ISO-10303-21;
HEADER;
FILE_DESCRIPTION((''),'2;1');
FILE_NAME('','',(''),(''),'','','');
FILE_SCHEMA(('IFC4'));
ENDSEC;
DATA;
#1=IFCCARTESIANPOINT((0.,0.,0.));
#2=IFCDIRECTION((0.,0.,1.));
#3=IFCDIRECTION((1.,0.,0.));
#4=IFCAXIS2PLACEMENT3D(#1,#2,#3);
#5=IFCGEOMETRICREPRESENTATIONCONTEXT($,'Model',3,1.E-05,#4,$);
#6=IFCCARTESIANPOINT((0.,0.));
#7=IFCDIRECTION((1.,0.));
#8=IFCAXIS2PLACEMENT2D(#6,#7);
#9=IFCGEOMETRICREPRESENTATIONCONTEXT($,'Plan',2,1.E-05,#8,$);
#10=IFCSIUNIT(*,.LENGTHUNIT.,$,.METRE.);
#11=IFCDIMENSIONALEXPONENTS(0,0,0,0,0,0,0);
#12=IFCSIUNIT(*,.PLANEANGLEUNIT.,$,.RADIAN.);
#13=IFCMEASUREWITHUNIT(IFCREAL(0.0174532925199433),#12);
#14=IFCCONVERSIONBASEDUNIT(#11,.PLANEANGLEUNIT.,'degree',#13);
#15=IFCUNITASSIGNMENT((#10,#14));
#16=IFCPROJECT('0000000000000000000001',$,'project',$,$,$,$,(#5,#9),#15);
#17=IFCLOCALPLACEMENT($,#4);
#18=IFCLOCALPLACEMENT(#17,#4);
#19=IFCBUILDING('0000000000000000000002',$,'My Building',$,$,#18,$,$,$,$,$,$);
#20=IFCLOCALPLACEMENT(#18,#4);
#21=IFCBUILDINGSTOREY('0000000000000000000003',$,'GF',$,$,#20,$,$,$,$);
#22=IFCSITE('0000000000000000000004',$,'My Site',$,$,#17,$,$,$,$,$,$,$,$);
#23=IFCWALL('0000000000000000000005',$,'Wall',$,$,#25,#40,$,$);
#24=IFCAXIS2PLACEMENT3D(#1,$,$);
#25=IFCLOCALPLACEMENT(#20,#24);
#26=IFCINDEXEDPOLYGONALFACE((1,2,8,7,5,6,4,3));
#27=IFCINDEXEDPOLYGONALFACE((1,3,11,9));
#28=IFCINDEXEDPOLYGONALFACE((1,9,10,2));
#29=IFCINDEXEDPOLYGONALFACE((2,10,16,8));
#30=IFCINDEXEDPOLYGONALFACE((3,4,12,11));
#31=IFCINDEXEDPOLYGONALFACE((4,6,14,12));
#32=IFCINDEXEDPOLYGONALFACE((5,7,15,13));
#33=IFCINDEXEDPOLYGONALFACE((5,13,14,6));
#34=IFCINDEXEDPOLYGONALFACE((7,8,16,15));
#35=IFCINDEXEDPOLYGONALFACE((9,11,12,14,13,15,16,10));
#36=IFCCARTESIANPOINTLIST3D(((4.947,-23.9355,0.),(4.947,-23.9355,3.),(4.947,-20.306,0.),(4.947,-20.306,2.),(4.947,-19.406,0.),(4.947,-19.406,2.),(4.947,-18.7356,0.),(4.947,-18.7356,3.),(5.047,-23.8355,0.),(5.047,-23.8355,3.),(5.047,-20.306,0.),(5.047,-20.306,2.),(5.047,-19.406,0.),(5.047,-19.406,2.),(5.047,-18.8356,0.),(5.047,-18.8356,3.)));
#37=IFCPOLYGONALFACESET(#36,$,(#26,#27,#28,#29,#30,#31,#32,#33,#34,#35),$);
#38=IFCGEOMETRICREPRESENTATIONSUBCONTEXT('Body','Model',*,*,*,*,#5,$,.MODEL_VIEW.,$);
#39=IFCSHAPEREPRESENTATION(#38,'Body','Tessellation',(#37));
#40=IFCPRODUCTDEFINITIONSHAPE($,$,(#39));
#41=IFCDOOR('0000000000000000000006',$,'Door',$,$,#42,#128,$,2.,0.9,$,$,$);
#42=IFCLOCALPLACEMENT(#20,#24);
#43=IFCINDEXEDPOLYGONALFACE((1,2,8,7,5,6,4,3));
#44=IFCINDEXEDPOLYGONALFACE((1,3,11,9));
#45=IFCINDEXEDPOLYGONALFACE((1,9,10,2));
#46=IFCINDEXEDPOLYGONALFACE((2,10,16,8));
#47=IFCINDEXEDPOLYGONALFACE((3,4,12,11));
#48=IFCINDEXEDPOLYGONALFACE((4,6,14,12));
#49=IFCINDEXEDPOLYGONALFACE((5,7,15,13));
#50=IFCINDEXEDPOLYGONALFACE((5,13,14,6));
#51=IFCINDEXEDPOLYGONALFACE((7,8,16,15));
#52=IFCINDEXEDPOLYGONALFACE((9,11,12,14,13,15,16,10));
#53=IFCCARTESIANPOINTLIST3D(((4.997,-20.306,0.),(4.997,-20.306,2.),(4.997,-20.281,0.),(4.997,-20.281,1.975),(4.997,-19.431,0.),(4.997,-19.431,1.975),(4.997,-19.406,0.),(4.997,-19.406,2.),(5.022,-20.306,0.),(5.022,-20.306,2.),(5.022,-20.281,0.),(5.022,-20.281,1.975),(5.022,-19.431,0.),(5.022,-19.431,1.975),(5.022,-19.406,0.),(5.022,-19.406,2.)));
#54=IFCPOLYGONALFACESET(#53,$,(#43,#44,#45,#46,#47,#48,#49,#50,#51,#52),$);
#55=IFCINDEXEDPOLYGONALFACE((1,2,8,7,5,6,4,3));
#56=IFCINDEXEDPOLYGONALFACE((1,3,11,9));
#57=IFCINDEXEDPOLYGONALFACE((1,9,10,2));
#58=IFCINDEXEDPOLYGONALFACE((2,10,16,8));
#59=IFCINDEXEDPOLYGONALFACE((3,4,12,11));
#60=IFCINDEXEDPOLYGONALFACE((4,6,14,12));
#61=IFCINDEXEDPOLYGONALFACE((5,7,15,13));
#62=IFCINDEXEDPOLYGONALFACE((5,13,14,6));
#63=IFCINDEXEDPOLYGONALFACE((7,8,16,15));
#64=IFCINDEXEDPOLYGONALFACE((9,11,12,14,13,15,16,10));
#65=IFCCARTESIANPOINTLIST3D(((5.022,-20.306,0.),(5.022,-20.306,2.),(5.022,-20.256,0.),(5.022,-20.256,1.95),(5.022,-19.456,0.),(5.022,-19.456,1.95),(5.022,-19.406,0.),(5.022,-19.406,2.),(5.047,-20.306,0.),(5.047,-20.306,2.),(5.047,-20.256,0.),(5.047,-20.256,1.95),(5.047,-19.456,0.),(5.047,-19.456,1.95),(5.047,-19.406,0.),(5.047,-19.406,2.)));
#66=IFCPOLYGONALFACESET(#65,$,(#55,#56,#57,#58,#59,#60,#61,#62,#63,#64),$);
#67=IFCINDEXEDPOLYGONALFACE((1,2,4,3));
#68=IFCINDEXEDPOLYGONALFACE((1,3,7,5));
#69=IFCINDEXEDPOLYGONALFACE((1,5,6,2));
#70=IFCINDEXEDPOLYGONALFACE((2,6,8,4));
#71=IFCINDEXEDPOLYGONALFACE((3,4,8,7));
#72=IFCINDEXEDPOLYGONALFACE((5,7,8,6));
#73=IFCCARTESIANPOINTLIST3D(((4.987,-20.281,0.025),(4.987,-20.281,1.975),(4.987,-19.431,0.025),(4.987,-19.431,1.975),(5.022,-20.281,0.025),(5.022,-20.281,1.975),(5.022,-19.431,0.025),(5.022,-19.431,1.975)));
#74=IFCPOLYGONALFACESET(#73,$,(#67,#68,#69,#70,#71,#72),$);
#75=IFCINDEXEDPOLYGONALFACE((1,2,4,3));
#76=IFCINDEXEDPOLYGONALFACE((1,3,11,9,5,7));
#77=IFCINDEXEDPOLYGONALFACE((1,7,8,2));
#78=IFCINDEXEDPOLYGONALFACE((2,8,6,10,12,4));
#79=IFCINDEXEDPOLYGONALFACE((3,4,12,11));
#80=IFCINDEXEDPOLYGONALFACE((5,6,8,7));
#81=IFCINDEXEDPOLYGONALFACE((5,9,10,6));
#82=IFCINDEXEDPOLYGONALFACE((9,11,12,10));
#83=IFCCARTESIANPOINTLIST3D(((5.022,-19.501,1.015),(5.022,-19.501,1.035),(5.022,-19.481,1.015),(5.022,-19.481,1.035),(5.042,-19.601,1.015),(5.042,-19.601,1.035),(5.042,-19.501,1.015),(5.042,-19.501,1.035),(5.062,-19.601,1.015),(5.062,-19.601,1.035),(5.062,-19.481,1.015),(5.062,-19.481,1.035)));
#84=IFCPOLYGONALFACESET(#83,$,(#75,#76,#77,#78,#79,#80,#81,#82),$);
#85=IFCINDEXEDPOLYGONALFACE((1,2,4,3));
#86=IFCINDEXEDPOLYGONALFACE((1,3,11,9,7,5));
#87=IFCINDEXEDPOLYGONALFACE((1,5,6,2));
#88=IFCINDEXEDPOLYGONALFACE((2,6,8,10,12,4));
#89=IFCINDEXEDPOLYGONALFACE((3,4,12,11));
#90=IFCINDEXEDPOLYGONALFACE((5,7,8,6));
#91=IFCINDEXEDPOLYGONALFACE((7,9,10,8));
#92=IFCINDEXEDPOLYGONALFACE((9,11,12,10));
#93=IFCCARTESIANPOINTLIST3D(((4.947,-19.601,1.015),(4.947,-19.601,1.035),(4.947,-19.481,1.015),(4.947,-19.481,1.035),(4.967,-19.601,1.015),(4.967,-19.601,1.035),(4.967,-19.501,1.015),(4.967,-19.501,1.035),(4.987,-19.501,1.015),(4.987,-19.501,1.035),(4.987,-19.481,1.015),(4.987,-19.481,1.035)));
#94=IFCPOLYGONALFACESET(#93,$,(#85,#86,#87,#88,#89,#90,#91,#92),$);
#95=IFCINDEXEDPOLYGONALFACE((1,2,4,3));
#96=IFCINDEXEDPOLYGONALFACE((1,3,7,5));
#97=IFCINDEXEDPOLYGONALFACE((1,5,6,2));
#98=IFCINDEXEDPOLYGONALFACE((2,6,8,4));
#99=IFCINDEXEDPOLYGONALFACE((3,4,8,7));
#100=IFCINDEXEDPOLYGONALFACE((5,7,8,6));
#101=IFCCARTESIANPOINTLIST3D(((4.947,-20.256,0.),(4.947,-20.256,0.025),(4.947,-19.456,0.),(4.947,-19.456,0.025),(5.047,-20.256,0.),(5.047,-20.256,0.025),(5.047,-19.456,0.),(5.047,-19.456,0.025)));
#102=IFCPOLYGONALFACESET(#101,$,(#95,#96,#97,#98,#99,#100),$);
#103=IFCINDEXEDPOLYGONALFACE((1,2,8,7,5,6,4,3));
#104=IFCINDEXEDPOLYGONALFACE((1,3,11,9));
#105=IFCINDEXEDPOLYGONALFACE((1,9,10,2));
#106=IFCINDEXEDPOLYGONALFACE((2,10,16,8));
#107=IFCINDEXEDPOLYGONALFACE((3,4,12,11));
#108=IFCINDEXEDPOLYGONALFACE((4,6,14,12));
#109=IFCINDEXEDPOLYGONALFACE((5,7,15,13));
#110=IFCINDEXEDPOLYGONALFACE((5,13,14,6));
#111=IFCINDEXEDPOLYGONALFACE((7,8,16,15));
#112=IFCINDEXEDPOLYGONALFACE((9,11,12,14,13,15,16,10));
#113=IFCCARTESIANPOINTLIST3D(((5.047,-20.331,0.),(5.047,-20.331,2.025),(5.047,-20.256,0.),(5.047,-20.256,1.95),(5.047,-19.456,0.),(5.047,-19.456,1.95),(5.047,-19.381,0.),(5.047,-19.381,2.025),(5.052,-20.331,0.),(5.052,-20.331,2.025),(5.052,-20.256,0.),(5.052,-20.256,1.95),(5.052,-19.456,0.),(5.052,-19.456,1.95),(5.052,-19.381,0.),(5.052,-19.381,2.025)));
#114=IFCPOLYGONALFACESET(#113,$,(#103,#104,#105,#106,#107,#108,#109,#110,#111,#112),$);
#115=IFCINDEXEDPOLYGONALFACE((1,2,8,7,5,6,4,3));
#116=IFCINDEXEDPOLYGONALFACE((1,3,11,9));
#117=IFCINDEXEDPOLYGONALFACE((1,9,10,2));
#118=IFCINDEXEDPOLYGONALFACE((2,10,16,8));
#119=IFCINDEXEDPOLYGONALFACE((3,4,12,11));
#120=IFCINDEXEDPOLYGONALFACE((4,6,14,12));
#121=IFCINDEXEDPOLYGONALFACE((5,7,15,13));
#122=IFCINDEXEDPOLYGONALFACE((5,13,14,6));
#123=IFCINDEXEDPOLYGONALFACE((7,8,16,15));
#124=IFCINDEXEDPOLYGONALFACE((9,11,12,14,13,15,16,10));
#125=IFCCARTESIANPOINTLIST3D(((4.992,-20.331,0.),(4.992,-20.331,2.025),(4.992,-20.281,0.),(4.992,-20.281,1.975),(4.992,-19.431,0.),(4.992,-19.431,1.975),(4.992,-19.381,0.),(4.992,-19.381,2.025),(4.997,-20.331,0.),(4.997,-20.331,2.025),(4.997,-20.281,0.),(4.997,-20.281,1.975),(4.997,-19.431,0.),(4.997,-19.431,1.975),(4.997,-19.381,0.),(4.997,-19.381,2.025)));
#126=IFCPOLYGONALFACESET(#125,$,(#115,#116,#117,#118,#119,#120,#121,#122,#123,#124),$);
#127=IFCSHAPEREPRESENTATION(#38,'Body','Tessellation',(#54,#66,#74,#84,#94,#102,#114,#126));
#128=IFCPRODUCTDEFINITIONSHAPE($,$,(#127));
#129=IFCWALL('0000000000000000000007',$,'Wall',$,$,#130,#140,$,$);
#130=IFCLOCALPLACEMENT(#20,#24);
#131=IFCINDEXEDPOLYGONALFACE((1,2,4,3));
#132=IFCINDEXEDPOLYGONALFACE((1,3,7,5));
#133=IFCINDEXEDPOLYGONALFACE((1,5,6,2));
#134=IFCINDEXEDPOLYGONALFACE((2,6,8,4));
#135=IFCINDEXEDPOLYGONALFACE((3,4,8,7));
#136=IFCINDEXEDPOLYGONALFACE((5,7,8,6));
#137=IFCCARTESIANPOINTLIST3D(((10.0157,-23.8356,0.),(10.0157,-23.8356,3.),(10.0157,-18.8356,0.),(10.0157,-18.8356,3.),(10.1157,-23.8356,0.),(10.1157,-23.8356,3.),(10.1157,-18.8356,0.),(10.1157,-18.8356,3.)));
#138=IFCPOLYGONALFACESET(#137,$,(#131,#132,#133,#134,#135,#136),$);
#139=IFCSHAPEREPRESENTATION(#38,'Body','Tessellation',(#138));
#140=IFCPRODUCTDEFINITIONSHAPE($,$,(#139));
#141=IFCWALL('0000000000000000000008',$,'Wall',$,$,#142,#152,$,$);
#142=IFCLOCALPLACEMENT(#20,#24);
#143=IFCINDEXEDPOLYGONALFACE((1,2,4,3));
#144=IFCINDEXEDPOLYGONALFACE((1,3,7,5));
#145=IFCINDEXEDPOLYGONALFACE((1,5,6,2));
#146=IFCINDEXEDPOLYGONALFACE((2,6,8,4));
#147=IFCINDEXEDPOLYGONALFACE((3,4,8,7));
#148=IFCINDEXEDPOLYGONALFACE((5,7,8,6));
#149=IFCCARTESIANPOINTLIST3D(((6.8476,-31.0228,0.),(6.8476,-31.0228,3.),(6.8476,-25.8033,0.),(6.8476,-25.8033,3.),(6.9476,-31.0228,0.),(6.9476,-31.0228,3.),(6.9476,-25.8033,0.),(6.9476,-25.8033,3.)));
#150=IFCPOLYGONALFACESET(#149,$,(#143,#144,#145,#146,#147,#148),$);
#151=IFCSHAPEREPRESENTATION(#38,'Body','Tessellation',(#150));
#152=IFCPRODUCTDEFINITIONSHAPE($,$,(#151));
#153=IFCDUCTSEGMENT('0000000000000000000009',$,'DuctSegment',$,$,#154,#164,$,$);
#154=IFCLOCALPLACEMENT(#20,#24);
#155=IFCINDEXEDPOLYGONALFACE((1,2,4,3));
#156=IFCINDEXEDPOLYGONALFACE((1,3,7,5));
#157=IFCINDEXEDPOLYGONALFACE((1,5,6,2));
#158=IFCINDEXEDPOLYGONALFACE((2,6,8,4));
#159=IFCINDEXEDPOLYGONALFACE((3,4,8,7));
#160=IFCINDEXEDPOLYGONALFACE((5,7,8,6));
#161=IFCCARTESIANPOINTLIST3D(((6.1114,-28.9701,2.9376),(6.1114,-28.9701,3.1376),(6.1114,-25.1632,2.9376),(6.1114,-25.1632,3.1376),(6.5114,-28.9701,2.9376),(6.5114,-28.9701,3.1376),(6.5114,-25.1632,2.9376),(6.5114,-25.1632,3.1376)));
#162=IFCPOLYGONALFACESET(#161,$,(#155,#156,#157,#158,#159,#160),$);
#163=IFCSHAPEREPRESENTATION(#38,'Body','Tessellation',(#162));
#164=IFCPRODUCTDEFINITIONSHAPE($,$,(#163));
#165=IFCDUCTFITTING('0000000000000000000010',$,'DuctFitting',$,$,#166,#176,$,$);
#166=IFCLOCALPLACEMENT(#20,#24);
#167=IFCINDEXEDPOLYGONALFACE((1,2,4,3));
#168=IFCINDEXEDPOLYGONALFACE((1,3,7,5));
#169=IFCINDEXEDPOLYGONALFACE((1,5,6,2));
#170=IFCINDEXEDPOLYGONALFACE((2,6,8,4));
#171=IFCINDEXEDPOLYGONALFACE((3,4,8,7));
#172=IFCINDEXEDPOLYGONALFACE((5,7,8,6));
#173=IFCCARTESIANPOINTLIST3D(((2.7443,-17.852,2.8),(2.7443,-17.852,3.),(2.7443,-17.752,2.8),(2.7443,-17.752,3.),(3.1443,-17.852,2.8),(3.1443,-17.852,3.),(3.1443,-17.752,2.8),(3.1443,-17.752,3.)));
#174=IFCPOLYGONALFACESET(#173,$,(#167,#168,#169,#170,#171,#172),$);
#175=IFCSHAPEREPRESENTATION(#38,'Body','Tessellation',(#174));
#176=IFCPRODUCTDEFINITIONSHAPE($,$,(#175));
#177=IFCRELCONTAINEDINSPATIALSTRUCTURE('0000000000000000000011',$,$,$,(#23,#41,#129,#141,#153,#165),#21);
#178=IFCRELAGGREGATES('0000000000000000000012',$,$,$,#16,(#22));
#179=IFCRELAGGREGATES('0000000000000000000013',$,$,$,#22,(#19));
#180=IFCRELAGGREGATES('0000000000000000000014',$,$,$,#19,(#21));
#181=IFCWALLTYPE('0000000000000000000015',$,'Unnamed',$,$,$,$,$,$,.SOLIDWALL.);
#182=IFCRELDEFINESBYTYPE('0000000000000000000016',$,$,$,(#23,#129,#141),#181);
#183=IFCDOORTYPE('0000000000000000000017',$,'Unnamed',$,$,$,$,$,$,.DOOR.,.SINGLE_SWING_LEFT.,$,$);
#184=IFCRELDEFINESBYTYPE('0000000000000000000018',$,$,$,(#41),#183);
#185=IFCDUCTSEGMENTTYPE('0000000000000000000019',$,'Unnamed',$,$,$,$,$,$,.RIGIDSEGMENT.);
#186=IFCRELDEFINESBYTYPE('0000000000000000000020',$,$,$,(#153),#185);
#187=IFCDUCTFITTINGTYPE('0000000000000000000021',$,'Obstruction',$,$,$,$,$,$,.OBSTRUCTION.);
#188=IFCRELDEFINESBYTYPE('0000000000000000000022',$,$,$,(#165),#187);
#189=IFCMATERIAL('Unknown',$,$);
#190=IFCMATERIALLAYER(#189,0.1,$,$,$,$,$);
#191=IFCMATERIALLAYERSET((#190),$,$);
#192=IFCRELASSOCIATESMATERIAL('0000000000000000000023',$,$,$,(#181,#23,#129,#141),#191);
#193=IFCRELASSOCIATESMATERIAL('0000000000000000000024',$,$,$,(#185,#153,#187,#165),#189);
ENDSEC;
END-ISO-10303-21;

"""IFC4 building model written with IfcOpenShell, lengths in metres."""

from ifc_helpers import new_model, entity, si_unit, converted_unit, frame, origin_with_axes, origin_2d_with_axis, place, context, subcontext, project, spatial, line, indexed_curve, rectangle, outline, extrude, shape, source, transform, mapped, material, layer, layer_set, layer_usage, material_profile, profile_set, profile_usage, type_object, type_shapes, element, fill, save


model = new_model("IFC4")

# Units and contexts
model_context = context("Model", 3, precision=1e-05, world=origin_with_axes())
plan_context = context("Plan", 2, precision=1e-05, world=origin_2d_with_axis())
body_context_1 = subcontext(model_context, "Body", "Model", "MODEL_VIEW")
body_context_2 = subcontext(plan_context, "Body", "Plan", "PLAN_VIEW")
ifc_project = project(units=[si_unit("LENGTHUNIT", "METRE"), converted_unit("PLANEANGLEUNIT", "degree", entity("IfcReal", 0.0174532925199433), si_unit("PLANEANGLEUNIT", "RADIAN"), dimensions=[0, 0, 0, 0, 0, 0, 0])], contexts=[model_context, plan_context])

# Site, building, storey
site_placement = place(None, origin_with_axes())
site = spatial("IfcSite", under=ifc_project, at=site_placement, Name="My Site")
building_placement = place(site_placement, origin_with_axes())
building = spatial("IfcBuilding", under=site, at=building_placement, Name="My Building")
storey_placement = place(building_placement, origin_with_axes())
storey = spatial("IfcBuildingStorey", under=building, at=storey_placement, Name="GF")

# Shared definitions
ifc_material = material(Name="Unknown")

# Shared definitions
ifc_layer_1 = layer(ifc_material, 0.1)
ifc_layer_set_1 = layer_set([ifc_layer_1])
wall_type = type_object("IfcWallType", Name="Unnamed", PredefinedType="SOLIDWALL", material=ifc_layer_set_1)

# Shared definitions
shared_shape_1 = source(origin_with_axes(), body_context_1, "Body", "SweptSolid", [
    extrude(outline(indexed_curve([(0.0, 0.0), (0.9, 0.0), (0.9, 2.0), (0.0, 2.0)], segments=[line(1, 2, 3, 4, 1)])), frame((0.0, -0.6, 0.0), z_axis=(0.0, -1.0, 0.0), x_axis=(1.0, 0.0, 0.0)), (0.0, 0.0, -1.0), 1.2),
])
door_type = type_object("IfcDoorType", Name="Unnamed", OperationType="SINGLE_SWING_LEFT", PredefinedType="DOOR")
shared_shape_2 = source(origin_with_axes(), body_context_1, "Body", "SweptSolid", [
    extrude(outline(indexed_curve([(0.0, 0.0), (0.0, 2.0), (0.9, 2.0), (0.9, 0.0), (0.875, 0.0), (0.875, 1.975), (0.025, 1.975), (0.025, 0.0)], segments=[line(1, 2, 3, 4, 5, 6, 7, 8, 1)])), frame((0.0, 0.025, 0.0), z_axis=(0.0, -1.0, 0.0), x_axis=(1.0, 0.0, 0.0)), (0.0, 0.0, -1.0), 0.025),
    extrude(outline(indexed_curve([(0.0, 0.0), (0.0, 2.0), (0.9, 2.0), (0.9, 0.0), (0.85, 0.0), (0.85, 1.95), (0.05, 1.95), (0.05, 0.0)], segments=[line(1, 2, 3, 4, 5, 6, 7, 8, 1)])), frame((0.0, 0.0, 0.0), z_axis=(0.0, -1.0, 0.0), x_axis=(1.0, 0.0, 0.0)), (0.0, 0.0, -1.0), 0.025),
    extrude(outline(indexed_curve([(0.0, 0.0), (0.85, 0.0), (0.85, 0.035), (0.0, 0.035)], segments=[line(1, 2, 3, 4, 1)])), frame((0.025, 0.025, 0.025), z_axis=(0.0, 0.0, 1.0), x_axis=(1.0, 0.0, 0.0)), (0.0, 0.0, 1.0), 1.95),
    extrude(outline(indexed_curve([(0.0, 0.0), (0.0, -0.04), (-0.12, -0.04), (-0.12, -0.02), (-0.02, -0.02), (-0.02, 0.0)], segments=[line(1, 2, 3, 4, 5, 6, 1)])), frame((0.825, 0.025, 1.015), z_axis=(0.0, 0.0, 1.0), x_axis=(1.0, 0.0, 0.0)), (0.0, 0.0, 1.0), 0.02),
    extrude(outline(indexed_curve([(0.0, 0.0), (0.0, 0.04), (-0.12, 0.04), (-0.12, 0.02), (-0.02, 0.02), (-0.02, 0.0)], segments=[line(1, 2, 3, 4, 5, 6, 1)])), frame((0.825, 0.06, 1.015), z_axis=(0.0, 0.0, 1.0), x_axis=(1.0, 0.0, 0.0)), (0.0, 0.0, 1.0), 0.02),
    extrude(outline(indexed_curve([(0.0, 0.0), (0.8, 0.0), (0.8, 0.1), (0.0, 0.1)], segments=[line(1, 2, 3, 4, 1)])), frame((0.05, 0.0, 0.0), z_axis=(0.0, 0.0, 1.0), x_axis=(1.0, 0.0, 0.0)), (0.0, 0.0, 1.0), 0.025),
    extrude(outline(indexed_curve([(0.0, 0.0), (0.0, 2.025), (0.95, 2.025), (0.95, 0.0), (0.875, 0.0), (0.875, 1.95), (0.075, 1.95), (0.075, 0.0)], segments=[line(1, 2, 3, 4, 5, 6, 7, 8, 1)])), frame((-0.025, -0.005, 0.0), z_axis=(0.0, -1.0, 0.0), x_axis=(1.0, 0.0, 0.0)), (0.0, 0.0, -1.0), 0.005),
    extrude(outline(indexed_curve([(0.0, 0.0), (0.0, 2.025), (0.95, 2.025), (0.95, 0.0), (0.9, 0.0), (0.9, 1.975), (0.05, 1.975), (0.05, 0.0)], segments=[line(1, 2, 3, 4, 5, 6, 7, 8, 1)])), frame((-0.025, 0.05, 0.0), z_axis=(0.0, -1.0, 0.0), x_axis=(1.0, 0.0, 0.0)), (0.0, 0.0, -1.0), 0.005),
])
shared_shape_3 = source(origin_with_axes(), body_context_2, "Body", "Curve2D", [
    entity("IfcIndexedPolyCurve", entity("IfcCartesianPointList2D", [[0.0, 0.0], [0.0, 0.05], [0.025, 0.05], [0.025, 0.025], [0.05, 0.025], [0.05, 0.0]]), [entity("IfcLineIndex", [1, 2, 3, 4, 5, 6, 1])]),
    entity("IfcIndexedPolyCurve", entity("IfcCartesianPointList2D", [[0.9, 0.0], [0.9, 0.05], [0.875, 0.05], [0.875, 0.025], [0.85, 0.025], [0.85, 0.0]]), [entity("IfcLineIndex", [1, 2, 3, 4, 5, 6, 1])]),
    entity("IfcTrimmedCurve", entity("IfcEllipse", entity("IfcAxis2Placement2D", entity("IfcCartesianPoint", [0.06, 0.05]), entity("IfcDirection", [1.0, 0.0])), 0.815, 0.85), [entity("IfcCartesianPoint", [0.875, 0.05])], [entity("IfcCartesianPoint", [0.06, 0.9])], True, "CARTESIAN"),
    entity("IfcIndexedPolyCurve", entity("IfcCartesianPointList2D", [[0.025, 0.05], [0.06, 0.05], [0.06, 0.9], [0.025, 0.9]]), [entity("IfcLineIndex", [1, 2, 3, 4, 1])]),
])
type_shapes(door_type, [shared_shape_2, shared_shape_3])

# Wall, opening, door
ifc_layer_usage_1 = layer_usage(ifc_layer_set_1, "AXIS2", "POSITIVE", 0.0)
wall_1_placement = place(storey_placement, frame((5.047, -23.8355, 0.0), z_axis=(0.0, 0.0, 1.0), x_axis=(0.0, 1.0, 0.0)))
wall_1 = element("IfcWall", 1, at=wall_1_placement, inside=storey, type_object=wall_type, material=ifc_layer_usage_1, Name="Wall", context=body_context_1, shape_type="SweptSolid", body=[
    extrude(outline(indexed_curve([(0.0, 0.0), (-0.1, 0.1), (5.1, 0.1), (5.0, 0.0)], segments=[line(1, 2, 3, 4, 1)])), origin_with_axes(), (0.0, 0.0, 1.0), 3.0),
])
opening_1_placement = place(wall_1_placement, frame((3.5295, 0.0, 0.0), z_axis=(0.0, 0.0, 1.0), x_axis=(1.0, 0.0, 0.0)))
opening_1 = element("IfcOpeningElement", 2, at=opening_1_placement, cuts=wall_1, PredefinedType="OPENING", context=body_context_1, shape_type="MappedRepresentation", body=[
    mapped(shared_shape_1, transform((0.0, 0.0, 0.0), x_axis=(1.0, 0.0, 0.0), y_axis=(0.0, 1.0, 0.0), z_axis=(0.0, 0.0, 1.0), scale=1.0)),
])
door_1_placement = place(opening_1_placement, frame((0.0, 0.0, 0.0), z_axis=(0.0, 0.0, 1.0), x_axis=(1.0, 0.0, 0.0)))
door_1 = element("IfcDoor", 3, at=door_1_placement, inside=storey, type_object=door_type, Name="Door", OverallHeight=2.0, OverallWidth=0.9, shapes=[
    shape(body_context_1, "Body", "MappedRepresentation", [mapped(shared_shape_2, transform((0.0, 0.0, 0.0), x_axis=(1.0, 0.0, 0.0), y_axis=(0.0, 1.0, 0.0), z_axis=(0.0, 0.0, 1.0), scale=1.0))]),
    shape(body_context_2, "Body", "MappedRepresentation", [mapped(shared_shape_3, transform((0.0, 0.0, 0.0), x_axis=(1.0, 0.0, 0.0), y_axis=(0.0, 1.0, 0.0), z_axis=(0.0, 0.0, 1.0), scale=1.0))]),
])
fill(opening_1, door_1)

# Walls
ifc_layer_usage_2 = layer_usage(ifc_layer_set_1, "AXIS2", "POSITIVE", 0.0)
wall_2_placement = place(storey_placement, frame((10.0157, -18.8356, 0.0), z_axis=(0.0, 0.0, 1.0), x_axis=(0.0, -1.0, 0.0)))
element("IfcWall", 4, at=wall_2_placement, inside=storey, type_object=wall_type, material=ifc_layer_usage_2, Name="Wall", context=body_context_1, shape_type="SweptSolid", body=[
    extrude(outline(indexed_curve([(0.0, 0.0), (0.0, 0.1), (5.0, 0.1), (5.0, 0.0)], segments=[line(1, 2, 3, 4, 1)])), origin_with_axes(), (0.0, 0.0, 1.0), 3.0),
])
ifc_layer_usage_3 = layer_usage(ifc_layer_set_1, "AXIS2", "POSITIVE", 0.0)
wall_3_placement = place(storey_placement, frame((6.8476, -25.8033, 0.0), z_axis=(0.0, 0.0, 1.0), x_axis=(0.0, -1.0, 0.0)))
element("IfcWall", 5, at=wall_3_placement, inside=storey, type_object=wall_type, material=ifc_layer_usage_3, Name="Wall", context=body_context_1, shape_type="SweptSolid", body=[
    extrude(outline(indexed_curve([(0.0, 0.0), (0.0, 0.1), (5.2195, 0.1), (5.2195, 0.0)], segments=[line(1, 2, 3, 4, 1)])), origin_with_axes(), (0.0, 0.0, 1.0), 3.0),
])

# Duct segment
ifc_material_profile_1 = material_profile(ifc_material, rectangle(XDim=0.4, YDim=0.2))
ifc_profile_set_1 = profile_set([ifc_material_profile_1])
ifc_profile_usage_1 = profile_usage(ifc_profile_set_1, cardinal=5)
duct_segment_type = type_object("IfcDuctSegmentType", Name="Unnamed", PredefinedType="RIGIDSEGMENT", material=ifc_profile_set_1)
duct_segment_placement = place(storey_placement, frame((6.3114, -28.9701, 3.0376), z_axis=(0.0, 1.0, 0.0), x_axis=(-1.0, 0.0, 0.0)))
element("IfcDuctSegment", 6, at=duct_segment_placement, inside=storey, type_object=duct_segment_type, material=ifc_profile_usage_1, Name="DuctSegment", context=body_context_1, shape_type="SweptSolid", body=[
    extrude(rectangle(XDim=0.4, YDim=0.2), origin_with_axes(), (0.0, 0.0, 1.0), 3.8069),
])

# Duct fitting
ifc_material_profile_2 = material_profile(ifc_material, rectangle(XDim=0.4, YDim=0.2))
ifc_profile_set_2 = profile_set([ifc_material_profile_2])
ifc_profile_usage_2 = profile_usage(ifc_profile_set_2, cardinal=5)
duct_fitting_type = type_object("IfcDuctFittingType", Name="Obstruction", PredefinedType="OBSTRUCTION", material=ifc_profile_set_2)
duct_fitting_1_placement = place(storey_placement, frame((2.9443, -17.852, 2.9), z_axis=(0.0, 1.0, 0.0), x_axis=(-1.0, 0.0, 0.0)))
element("IfcDuctFitting", 7, at=duct_fitting_1_placement, inside=storey, type_object=duct_fitting_type, material=ifc_profile_usage_2, Name="DuctFitting", context=body_context_1, shape_type="SweptSolid", body=[
    extrude(rectangle(XDim=0.4, YDim=0.2), origin_with_axes(), (0.0, 0.0, 1.0), 0.1),
])

save(model, "model.ifc")
